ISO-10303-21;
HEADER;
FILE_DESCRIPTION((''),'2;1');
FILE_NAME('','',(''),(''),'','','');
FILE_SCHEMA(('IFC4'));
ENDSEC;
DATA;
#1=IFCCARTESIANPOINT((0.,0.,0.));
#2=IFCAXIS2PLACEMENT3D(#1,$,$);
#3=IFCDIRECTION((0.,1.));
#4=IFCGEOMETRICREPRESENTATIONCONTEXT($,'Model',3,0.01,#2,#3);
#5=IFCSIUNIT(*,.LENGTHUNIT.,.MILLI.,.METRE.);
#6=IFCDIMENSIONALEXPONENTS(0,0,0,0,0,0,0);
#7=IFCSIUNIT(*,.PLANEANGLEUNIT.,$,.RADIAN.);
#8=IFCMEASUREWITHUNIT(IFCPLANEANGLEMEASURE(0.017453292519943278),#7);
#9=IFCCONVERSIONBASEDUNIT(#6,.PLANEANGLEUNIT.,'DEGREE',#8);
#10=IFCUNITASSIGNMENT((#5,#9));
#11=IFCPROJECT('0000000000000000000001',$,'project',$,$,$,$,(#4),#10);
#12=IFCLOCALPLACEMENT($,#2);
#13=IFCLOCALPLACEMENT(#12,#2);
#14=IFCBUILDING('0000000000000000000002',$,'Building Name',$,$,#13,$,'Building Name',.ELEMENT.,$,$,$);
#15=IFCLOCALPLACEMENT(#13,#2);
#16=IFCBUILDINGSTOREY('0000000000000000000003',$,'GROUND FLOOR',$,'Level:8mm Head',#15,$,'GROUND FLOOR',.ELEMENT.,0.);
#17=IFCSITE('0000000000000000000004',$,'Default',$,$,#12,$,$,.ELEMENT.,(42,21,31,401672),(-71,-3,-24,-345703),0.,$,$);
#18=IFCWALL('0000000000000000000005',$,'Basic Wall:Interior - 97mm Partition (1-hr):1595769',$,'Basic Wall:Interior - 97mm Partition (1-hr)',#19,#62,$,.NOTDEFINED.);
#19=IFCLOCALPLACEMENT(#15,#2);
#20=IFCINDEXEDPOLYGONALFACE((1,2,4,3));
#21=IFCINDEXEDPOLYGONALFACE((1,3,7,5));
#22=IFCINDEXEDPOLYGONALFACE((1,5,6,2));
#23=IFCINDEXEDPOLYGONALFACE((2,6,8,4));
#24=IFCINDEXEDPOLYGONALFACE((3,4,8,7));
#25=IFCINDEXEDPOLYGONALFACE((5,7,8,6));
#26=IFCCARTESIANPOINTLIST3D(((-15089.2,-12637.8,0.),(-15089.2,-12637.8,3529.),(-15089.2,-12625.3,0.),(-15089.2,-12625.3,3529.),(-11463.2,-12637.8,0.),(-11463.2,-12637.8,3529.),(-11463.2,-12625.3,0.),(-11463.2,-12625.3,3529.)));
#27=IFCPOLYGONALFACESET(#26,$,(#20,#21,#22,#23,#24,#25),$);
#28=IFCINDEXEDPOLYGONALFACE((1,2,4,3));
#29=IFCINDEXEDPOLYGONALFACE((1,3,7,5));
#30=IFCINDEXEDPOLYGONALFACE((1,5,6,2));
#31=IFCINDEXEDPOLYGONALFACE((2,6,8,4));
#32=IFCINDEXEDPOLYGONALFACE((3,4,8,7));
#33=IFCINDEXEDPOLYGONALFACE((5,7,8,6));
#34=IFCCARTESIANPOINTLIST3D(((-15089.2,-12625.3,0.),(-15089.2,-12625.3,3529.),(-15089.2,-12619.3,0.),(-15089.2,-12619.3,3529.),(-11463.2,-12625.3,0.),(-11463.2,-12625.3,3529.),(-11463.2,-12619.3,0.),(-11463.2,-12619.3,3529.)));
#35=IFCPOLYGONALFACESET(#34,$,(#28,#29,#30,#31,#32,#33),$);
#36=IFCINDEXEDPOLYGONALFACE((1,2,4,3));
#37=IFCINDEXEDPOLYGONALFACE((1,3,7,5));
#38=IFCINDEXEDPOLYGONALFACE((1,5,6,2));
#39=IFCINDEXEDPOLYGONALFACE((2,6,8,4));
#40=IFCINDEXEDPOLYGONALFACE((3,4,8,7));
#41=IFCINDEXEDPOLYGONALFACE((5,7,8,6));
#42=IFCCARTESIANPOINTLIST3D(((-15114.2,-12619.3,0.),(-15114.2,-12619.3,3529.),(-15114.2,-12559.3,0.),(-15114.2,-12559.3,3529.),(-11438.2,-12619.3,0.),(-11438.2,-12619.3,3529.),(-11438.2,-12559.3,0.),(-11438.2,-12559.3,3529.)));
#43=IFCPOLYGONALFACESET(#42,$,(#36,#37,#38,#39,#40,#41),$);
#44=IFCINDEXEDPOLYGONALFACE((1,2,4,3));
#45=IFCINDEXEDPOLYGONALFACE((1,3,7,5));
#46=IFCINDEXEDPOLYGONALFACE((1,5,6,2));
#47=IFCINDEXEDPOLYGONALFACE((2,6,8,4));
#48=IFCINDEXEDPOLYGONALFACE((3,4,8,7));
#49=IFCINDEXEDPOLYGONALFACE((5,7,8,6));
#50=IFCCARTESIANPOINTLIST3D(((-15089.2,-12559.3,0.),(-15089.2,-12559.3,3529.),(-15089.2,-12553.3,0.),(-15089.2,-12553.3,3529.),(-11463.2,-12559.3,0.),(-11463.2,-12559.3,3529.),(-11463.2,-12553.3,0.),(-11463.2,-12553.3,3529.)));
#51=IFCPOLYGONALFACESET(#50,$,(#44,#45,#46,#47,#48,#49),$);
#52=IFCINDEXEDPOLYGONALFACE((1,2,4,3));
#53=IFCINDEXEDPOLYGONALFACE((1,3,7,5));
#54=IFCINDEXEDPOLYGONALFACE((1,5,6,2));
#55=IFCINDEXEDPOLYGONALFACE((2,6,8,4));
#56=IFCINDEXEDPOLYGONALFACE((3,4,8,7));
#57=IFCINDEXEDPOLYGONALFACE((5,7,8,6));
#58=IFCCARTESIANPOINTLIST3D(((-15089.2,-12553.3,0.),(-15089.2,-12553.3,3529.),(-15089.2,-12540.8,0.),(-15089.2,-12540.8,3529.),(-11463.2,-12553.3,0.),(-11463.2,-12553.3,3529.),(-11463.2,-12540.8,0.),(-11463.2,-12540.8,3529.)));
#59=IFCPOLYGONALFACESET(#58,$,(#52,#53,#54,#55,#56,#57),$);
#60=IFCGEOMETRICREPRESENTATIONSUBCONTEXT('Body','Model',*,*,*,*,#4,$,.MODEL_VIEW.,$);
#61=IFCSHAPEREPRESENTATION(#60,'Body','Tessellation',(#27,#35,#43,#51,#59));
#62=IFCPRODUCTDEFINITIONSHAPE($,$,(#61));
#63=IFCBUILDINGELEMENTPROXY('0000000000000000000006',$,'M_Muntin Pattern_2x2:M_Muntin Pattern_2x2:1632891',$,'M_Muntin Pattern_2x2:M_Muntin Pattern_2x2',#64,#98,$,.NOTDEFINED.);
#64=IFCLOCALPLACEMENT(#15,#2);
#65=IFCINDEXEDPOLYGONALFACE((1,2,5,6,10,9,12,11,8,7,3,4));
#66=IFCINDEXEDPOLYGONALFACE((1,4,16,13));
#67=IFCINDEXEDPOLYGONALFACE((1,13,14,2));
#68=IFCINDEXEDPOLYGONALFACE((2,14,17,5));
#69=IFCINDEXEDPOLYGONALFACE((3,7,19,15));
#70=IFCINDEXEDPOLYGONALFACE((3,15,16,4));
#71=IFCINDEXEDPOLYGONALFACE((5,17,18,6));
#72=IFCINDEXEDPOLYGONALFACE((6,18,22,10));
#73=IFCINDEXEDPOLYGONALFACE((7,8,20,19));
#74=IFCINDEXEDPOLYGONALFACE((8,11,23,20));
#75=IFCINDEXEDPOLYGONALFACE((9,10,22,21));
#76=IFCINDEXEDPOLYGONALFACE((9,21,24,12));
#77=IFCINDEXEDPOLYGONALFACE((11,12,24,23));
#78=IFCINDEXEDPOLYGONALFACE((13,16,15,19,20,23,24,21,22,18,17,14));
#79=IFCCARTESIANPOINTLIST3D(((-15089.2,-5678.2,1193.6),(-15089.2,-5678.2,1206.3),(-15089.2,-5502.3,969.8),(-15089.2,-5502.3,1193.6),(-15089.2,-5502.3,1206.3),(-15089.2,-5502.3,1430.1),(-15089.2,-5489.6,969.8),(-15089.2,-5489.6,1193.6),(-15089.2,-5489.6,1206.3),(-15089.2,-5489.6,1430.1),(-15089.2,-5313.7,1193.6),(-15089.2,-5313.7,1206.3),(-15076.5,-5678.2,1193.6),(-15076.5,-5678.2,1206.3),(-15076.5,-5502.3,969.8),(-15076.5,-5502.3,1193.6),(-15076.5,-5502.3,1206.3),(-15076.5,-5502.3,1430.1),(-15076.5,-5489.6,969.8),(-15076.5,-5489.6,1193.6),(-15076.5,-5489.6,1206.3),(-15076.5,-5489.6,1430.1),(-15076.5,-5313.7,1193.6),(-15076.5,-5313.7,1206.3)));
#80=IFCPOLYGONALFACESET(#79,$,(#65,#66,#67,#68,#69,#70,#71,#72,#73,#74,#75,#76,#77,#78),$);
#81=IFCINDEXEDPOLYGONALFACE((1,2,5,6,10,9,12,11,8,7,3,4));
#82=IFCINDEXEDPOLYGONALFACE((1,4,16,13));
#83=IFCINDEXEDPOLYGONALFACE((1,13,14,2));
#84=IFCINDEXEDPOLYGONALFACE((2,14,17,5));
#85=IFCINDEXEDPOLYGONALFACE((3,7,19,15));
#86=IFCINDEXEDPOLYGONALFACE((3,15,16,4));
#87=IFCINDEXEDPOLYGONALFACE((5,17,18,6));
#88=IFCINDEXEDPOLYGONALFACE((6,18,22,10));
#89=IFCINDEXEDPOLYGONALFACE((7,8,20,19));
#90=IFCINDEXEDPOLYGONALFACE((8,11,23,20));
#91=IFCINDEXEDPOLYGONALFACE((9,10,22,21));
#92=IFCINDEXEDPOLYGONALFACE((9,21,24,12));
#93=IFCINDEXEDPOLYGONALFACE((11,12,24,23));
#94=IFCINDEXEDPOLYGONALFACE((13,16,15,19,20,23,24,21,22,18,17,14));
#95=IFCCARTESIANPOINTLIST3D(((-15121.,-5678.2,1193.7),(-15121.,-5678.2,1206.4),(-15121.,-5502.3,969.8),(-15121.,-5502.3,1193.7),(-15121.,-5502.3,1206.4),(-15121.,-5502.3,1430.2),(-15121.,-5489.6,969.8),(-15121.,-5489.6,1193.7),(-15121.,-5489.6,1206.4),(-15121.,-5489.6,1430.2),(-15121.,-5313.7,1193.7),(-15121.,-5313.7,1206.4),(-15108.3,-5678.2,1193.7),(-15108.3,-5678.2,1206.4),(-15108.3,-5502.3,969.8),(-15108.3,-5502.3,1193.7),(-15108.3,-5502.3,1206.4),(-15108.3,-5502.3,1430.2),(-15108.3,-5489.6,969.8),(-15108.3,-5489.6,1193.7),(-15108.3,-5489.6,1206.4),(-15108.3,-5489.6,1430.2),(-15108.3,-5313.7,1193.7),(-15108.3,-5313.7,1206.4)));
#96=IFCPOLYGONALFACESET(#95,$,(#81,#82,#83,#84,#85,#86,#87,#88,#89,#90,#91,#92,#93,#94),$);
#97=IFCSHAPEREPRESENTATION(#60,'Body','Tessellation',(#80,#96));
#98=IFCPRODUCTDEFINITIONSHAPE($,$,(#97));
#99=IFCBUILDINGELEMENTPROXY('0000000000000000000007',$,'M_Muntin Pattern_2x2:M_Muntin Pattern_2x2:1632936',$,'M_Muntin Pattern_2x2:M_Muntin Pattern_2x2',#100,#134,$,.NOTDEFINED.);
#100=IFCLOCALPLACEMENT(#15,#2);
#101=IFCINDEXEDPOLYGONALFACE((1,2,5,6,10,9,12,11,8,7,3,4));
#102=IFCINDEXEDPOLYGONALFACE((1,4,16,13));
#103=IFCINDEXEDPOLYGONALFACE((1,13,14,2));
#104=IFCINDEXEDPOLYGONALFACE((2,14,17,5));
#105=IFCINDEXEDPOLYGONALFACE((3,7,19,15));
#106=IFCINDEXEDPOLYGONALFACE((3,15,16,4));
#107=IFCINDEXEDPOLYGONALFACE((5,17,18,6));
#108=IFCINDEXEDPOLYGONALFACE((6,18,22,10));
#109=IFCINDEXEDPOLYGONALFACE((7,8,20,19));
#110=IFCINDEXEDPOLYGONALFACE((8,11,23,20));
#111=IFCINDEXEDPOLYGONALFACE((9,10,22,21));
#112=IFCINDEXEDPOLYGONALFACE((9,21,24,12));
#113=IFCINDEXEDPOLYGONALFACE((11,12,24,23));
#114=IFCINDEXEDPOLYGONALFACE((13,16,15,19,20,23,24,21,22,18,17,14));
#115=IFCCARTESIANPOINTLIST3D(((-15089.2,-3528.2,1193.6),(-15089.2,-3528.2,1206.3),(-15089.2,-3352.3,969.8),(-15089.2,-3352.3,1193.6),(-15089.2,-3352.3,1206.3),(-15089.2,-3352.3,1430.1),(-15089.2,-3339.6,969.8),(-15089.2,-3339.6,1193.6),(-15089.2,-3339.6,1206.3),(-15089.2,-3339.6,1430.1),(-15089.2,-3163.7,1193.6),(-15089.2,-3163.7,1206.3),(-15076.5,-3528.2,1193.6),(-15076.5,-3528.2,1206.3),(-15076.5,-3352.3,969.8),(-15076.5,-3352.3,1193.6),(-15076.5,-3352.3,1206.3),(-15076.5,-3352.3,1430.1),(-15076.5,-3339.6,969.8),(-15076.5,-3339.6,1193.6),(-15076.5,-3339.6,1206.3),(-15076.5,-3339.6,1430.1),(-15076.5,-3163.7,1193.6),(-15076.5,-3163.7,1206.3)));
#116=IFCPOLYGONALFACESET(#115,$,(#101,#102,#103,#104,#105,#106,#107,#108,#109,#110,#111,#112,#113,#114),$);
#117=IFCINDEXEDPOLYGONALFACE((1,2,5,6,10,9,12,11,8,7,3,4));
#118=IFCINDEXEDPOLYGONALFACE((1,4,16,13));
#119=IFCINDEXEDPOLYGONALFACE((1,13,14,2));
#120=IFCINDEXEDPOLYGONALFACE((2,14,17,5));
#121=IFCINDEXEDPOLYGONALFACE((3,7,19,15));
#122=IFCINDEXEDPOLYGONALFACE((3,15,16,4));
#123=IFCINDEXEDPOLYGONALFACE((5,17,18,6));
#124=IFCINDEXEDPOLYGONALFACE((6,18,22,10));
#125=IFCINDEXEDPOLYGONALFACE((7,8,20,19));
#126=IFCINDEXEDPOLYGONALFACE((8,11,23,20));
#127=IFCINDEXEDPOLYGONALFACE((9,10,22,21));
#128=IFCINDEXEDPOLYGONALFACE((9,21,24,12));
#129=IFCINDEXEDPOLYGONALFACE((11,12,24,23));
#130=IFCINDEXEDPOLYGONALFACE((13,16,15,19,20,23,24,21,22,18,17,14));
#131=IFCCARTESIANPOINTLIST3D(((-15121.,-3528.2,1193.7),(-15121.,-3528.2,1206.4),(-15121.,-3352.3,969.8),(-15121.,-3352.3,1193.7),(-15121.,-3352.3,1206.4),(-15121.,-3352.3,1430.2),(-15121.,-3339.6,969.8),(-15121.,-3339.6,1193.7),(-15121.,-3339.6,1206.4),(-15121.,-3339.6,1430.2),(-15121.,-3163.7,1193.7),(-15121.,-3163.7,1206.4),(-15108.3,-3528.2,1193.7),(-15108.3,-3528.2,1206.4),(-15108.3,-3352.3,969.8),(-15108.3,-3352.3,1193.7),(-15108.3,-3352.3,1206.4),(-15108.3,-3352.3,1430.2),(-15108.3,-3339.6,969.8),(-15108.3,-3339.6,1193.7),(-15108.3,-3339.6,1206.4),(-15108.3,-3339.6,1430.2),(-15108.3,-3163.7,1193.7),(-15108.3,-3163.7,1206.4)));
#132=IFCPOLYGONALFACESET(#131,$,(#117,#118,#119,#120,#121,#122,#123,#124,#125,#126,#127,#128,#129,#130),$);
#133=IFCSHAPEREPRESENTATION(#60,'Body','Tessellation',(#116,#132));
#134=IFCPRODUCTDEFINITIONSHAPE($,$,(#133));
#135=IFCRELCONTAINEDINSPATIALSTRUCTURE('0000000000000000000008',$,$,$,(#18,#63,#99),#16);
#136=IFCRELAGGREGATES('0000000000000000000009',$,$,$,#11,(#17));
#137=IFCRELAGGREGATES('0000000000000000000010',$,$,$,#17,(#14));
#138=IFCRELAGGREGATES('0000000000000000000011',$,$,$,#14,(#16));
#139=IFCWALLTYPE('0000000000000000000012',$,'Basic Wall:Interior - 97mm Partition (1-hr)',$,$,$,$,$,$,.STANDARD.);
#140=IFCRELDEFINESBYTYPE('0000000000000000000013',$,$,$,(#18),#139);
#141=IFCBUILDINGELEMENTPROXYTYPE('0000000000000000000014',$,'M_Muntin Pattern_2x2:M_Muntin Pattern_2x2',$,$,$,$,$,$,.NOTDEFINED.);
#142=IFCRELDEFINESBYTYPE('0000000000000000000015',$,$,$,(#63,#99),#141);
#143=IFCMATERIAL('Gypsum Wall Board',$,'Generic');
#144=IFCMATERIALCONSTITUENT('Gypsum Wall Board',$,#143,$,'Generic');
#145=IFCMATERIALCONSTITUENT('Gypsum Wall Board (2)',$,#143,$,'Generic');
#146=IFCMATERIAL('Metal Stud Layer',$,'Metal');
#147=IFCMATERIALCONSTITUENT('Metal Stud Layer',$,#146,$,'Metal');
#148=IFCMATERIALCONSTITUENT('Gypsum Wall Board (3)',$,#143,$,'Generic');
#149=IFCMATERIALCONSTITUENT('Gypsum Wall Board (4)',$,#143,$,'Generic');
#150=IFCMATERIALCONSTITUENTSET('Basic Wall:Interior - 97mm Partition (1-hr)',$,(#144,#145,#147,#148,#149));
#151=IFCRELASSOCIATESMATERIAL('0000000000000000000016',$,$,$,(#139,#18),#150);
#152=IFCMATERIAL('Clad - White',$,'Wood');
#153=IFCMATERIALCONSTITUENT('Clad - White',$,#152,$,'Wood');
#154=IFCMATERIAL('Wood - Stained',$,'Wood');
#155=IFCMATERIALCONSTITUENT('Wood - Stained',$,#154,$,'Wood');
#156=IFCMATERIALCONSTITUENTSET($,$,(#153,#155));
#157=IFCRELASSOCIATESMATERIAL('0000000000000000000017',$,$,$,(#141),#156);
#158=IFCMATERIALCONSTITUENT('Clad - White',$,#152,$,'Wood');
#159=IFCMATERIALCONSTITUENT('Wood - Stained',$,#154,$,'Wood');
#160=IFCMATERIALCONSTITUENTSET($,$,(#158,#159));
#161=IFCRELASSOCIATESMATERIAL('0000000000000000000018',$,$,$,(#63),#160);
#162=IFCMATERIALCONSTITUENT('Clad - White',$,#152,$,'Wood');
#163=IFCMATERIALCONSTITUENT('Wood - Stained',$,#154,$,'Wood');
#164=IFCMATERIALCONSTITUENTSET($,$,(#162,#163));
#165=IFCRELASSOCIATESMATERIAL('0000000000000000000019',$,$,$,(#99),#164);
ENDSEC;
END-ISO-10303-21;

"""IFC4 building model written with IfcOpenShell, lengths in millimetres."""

from ifc_helpers import new_model, entity, si_unit, converted_unit, direction, frame, origin, place, context, subcontext, project, spatial, indexed_curve, outline, extrude, source, transform, mapped, material, constituent, constituent_set, type_object, type_shapes, element, save


model = new_model("IFC4")

# Units and contexts
model_context = context("Model", 3, precision=0.01, world=origin(), true_north=direction((0.0, 1.0)))
body_context = subcontext(model_context, "Body", "Model", "MODEL_VIEW")
ifc_project = project(units=[si_unit("LENGTHUNIT", "METRE", prefix="MILLI"), converted_unit("PLANEANGLEUNIT", "DEGREE", entity("IfcPlaneAngleMeasure", 0.017453292519943278), si_unit("PLANEANGLEUNIT", "RADIAN"), dimensions=[0, 0, 0, 0, 0, 0, 0])], contexts=[model_context])

# Site, building, storey
site_placement = place(None, origin())
site = spatial("IfcSite", under=ifc_project, at=site_placement, Name="Default", CompositionType="ELEMENT", RefLatitude=(42, 21, 31, 401672), RefLongitude=(-71, -3, -24, -345703), RefElevation=0.0)
building_placement = place(site_placement, origin())
building = spatial("IfcBuilding", under=site, at=building_placement, Name="Building Name", LongName="Building Name", CompositionType="ELEMENT")
storey_placement = place(building_placement, origin())
storey = spatial("IfcBuildingStorey", under=building, at=storey_placement, Name="GROUND FLOOR", ObjectType="Level:8mm Head", LongName="GROUND FLOOR", CompositionType="ELEMENT", Elevation=0.0)

# Shared definitions
ifc_material_1 = material(Name="Wood - Stained", Category="Wood")

# Wall
ifc_material_2 = material(Name="Gypsum Wall Board", Category="Generic")
ifc_constituent_1 = constituent(ifc_material_2, Name="Gypsum Wall Board", Category="Generic")
ifc_constituent_2 = constituent(ifc_material_2, Name="Gypsum Wall Board (2)", Category="Generic")
ifc_material_3 = material(Name="Metal Stud Layer", Category="Metal")
ifc_constituent_3 = constituent(ifc_material_3, Name="Metal Stud Layer", Category="Metal")
ifc_constituent_4 = constituent(ifc_material_2, Name="Gypsum Wall Board (3)", Category="Generic")
ifc_constituent_5 = constituent(ifc_material_2, Name="Gypsum Wall Board (4)", Category="Generic")
ifc_constituent_set_1 = constituent_set(constituents=[ifc_constituent_1, ifc_constituent_2, ifc_constituent_3, ifc_constituent_4, ifc_constituent_5], Name="Basic Wall:Interior - 97mm Partition (1-hr)")
wall_type_1 = type_object("IfcWallType", Name="Basic Wall:Interior - 97mm Partition (1-hr)", PredefinedType="STANDARD", material=ifc_constituent_set_1)
wall_1_placement = place(storey_placement, frame((-15089.2, -12589.3, 0.0)))
element("IfcWall", 1, at=wall_1_placement, inside=storey, type_object=wall_type_1, material=ifc_constituent_set_1, Name="Basic Wall:Interior - 97mm Partition (1-hr):1595769", ObjectType="Basic Wall:Interior - 97mm Partition (1-hr)", PredefinedType="NOTDEFINED", context=body_context, shape_type="SweptSolid", body=[
    extrude(outline(indexed_curve([(-6.3, -1813.0), (6.2, -1813.0), (6.3, 1813.0), (-6.2, 1813.0), (-6.3, -1813.0)], self_intersect=False)), frame((1813.0, -42.2, 0.0), z_axis=(0.0, 0.0, 1.0), x_axis=(0.0, 1.0, 0.0)), (0.0, 0.0, 1.0), 3529.0),
    extrude(outline(indexed_curve([(-1813.0, -3.0), (1813.0, -3.0), (1813.0, 3.0), (-1813.0, 3.0), (-1813.0, -3.0)], self_intersect=False)), frame((1813.0, -33.0, 0.0)), (0.0, 0.0, 1.0), 3529.0),
    extrude(outline(indexed_curve([(-1838.0, -30.0), (1838.0, -30.0), (1838.0, 30.0), (-1838.0, 30.0), (-1838.0, -30.0)], self_intersect=False)), frame((1813.0, 0.0, 0.0)), (0.0, 0.0, 1.0), 3529.0),
    extrude(outline(indexed_curve([(-1813.0, -3.0), (1813.0, -3.0), (1813.0, 3.0), (-1813.0, 3.0), (-1813.0, -3.0)], self_intersect=False)), frame((1813.0, 33.0, 0.0)), (0.0, 0.0, 1.0), 3529.0),
    extrude(outline(indexed_curve([(-6.3, -1813.0), (6.2, -1813.0), (6.3, 1813.0), (-6.2, 1813.0), (-6.3, -1813.0)], self_intersect=False)), frame((1813.0, 42.2, 0.0), z_axis=(0.0, 0.0, 1.0), x_axis=(0.0, -1.0, 0.0)), (0.0, 0.0, 1.0), 3529.0),
])

# Building element proxies
ifc_material_4 = material(Name="Clad - White", Category="Wood")
ifc_constituent_6 = constituent(ifc_material_4, Name="Clad - White", Category="Wood")
ifc_constituent_7 = constituent(ifc_material_1, Name="Wood - Stained", Category="Wood")
ifc_constituent_set_2 = constituent_set(constituents=[ifc_constituent_6, ifc_constituent_7])
ifc_constituent_8 = constituent(ifc_material_4, Name="Clad - White", Category="Wood")
ifc_constituent_9 = constituent(ifc_material_1, Name="Wood - Stained", Category="Wood")
ifc_constituent_set_3 = constituent_set(constituents=[ifc_constituent_8, ifc_constituent_9])
building_element_proxy_type_1 = type_object("IfcBuildingElementProxyType", Name="M_Muntin Pattern_2x2:M_Muntin Pattern_2x2", PredefinedType="NOTDEFINED", material=ifc_constituent_set_3)
shared_shape_1 = source(origin(), body_context, "Body", "SweptSolid", [
    extrude(outline(indexed_curve([(6.4, -6.4), (230.1, -6.4), (230.1, 6.3), (6.4, 6.3), (6.4, 182.3), (-6.3, 182.3), (-6.3, 6.3), (-230.2, 6.3), (-230.2, -6.4), (-6.3, -6.4), (-6.3, -182.3), (6.4, -182.3), (6.4, -6.4)], self_intersect=False)), frame((0.0, 9.5, 230.1), z_axis=(0.0, 1.0, 0.0), x_axis=(0.0, 0.0, 1.0)), (0.0, 0.0, 1.0), 12.7),
    extrude(outline(indexed_curve([(6.4, -6.4), (230.2, -6.4), (230.2, 6.3), (6.4, 6.3), (6.4, 182.3), (-6.3, 182.3), (-6.3, 6.3), (-230.2, 6.3), (-230.2, -6.4), (-6.3, -6.4), (-6.3, -182.3), (6.4, -182.3), (6.4, -6.4)], self_intersect=False)), frame((0.0, -22.2, 230.2), z_axis=(0.0, 1.0, 0.0), x_axis=(0.0, 0.0, 1.0)), (0.0, 0.0, 1.0), 12.7),
])
type_shapes(building_element_proxy_type_1, [shared_shape_1])
proxy_1_placement = place(storey_placement, frame((-15098.7, -5495.9, 969.8), z_axis=(0.0, 0.0, 1.0), x_axis=(0.0, -1.0, 0.0)))
element("IfcBuildingElementProxy", 2, at=proxy_1_placement, inside=storey, type_object=building_element_proxy_type_1, material=ifc_constituent_set_2, Name="M_Muntin Pattern_2x2:M_Muntin Pattern_2x2:1632891", ObjectType="M_Muntin Pattern_2x2:M_Muntin Pattern_2x2", PredefinedType="NOTDEFINED", context=body_context, shape_type="MappedRepresentation", body=[
    mapped(shared_shape_1, transform((0.0, 0.0, 0.0), scale=1.0)),
])
ifc_constituent_10 = constituent(ifc_material_4, Name="Clad - White", Category="Wood")
ifc_constituent_11 = constituent(ifc_material_1, Name="Wood - Stained", Category="Wood")
ifc_constituent_set_4 = constituent_set(constituents=[ifc_constituent_10, ifc_constituent_11])
proxy_2_placement = place(storey_placement, frame((-15098.7, -3345.9, 969.8), z_axis=(0.0, 0.0, 1.0), x_axis=(0.0, -1.0, 0.0)))
element("IfcBuildingElementProxy", 3, at=proxy_2_placement, inside=storey, type_object=building_element_proxy_type_1, material=ifc_constituent_set_4, Name="M_Muntin Pattern_2x2:M_Muntin Pattern_2x2:1632936", ObjectType="M_Muntin Pattern_2x2:M_Muntin Pattern_2x2", PredefinedType="NOTDEFINED", context=body_context, shape_type="MappedRepresentation", body=[
    mapped(shared_shape_1, transform((0.0, 0.0, 0.0), scale=1.0)),
])

save(model, "model.ifc")
